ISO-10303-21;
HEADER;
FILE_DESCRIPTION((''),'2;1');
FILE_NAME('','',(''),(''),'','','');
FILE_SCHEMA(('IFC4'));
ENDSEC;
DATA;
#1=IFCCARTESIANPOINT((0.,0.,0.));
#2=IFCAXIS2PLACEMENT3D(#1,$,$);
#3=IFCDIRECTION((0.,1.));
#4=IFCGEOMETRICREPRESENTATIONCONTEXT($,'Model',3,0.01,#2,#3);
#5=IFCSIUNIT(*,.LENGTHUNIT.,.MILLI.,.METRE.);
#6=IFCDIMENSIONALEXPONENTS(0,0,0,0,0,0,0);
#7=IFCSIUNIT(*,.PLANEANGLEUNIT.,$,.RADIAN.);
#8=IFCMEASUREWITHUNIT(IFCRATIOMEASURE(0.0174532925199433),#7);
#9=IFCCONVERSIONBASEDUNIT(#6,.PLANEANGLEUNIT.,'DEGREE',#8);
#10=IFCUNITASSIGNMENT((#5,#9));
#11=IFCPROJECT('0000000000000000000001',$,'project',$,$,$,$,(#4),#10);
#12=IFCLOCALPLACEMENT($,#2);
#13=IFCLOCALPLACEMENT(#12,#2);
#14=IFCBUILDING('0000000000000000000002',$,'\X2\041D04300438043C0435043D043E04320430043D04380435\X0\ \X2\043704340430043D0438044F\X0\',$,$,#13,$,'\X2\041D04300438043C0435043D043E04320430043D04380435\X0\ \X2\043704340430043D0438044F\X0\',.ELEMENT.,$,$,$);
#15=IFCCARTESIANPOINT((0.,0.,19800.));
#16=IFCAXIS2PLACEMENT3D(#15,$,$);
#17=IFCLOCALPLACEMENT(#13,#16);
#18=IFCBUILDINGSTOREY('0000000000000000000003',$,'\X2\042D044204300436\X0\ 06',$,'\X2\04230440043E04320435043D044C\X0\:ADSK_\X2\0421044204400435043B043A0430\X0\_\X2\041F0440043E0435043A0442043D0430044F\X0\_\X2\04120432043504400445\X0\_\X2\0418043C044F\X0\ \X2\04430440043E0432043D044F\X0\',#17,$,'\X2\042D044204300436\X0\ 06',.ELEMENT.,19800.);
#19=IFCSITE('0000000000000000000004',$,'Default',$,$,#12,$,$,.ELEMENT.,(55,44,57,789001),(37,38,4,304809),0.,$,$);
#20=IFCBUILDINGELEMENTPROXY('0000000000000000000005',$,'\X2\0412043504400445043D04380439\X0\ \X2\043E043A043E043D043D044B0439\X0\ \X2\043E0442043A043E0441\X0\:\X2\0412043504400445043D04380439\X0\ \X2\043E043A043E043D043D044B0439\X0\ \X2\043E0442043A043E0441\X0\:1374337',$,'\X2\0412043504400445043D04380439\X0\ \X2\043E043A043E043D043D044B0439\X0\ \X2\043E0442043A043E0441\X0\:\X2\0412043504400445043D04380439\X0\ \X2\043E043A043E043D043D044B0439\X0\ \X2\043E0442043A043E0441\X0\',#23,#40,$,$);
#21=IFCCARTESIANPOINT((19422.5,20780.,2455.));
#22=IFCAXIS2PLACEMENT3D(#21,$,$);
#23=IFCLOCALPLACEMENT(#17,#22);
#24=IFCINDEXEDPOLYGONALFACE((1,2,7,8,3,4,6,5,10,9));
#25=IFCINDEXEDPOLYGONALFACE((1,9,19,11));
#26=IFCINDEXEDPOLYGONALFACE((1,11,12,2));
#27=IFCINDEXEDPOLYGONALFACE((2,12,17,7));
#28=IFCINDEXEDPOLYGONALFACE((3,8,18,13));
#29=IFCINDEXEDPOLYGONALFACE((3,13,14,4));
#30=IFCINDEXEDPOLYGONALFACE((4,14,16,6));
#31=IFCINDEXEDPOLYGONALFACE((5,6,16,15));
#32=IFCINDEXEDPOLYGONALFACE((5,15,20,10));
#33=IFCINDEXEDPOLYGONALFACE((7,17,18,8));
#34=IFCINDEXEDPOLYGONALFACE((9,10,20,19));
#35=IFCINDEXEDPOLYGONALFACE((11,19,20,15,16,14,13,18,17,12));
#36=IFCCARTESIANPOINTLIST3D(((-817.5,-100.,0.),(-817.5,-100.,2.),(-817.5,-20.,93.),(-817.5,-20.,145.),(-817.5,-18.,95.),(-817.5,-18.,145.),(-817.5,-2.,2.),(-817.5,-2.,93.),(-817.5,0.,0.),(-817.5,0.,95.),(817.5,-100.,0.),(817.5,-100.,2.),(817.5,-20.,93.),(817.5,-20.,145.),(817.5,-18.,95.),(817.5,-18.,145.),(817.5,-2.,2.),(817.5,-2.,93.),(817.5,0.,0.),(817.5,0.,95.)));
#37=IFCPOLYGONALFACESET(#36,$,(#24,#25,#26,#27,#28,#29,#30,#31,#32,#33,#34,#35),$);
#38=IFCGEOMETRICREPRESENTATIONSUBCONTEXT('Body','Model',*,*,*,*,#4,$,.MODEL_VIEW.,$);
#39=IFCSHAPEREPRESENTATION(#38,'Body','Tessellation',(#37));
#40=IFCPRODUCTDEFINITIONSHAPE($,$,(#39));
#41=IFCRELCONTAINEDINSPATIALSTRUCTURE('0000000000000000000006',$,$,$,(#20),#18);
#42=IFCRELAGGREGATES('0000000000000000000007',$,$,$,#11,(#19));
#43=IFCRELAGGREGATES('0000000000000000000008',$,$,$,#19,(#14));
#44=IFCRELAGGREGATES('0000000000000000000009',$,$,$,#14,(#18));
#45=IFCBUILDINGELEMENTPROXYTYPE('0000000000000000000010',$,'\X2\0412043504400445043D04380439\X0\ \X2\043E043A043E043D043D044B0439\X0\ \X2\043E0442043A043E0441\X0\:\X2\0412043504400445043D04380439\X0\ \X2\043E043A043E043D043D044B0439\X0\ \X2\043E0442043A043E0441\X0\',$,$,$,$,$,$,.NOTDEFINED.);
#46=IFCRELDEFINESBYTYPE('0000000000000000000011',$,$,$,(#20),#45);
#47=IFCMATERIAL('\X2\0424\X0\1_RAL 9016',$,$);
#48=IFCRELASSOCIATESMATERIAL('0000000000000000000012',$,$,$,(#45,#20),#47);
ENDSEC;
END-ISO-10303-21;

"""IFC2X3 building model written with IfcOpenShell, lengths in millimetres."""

from ifc_helpers import new_model, entity, si_unit, converted_unit, direction, frame, origin, place, context, subcontext, project, spatial, polyline, outline, extrude, source, transform, mapped, material, type_object, type_shapes, element, save


model = new_model("IFC2X3")

# Units and contexts
model_context = context("Model", 3, precision=0.01, world=origin(), true_north=direction((0.0, 1.0)))
body_context = subcontext(model_context, "Body", "Model", "MODEL_VIEW")
ifc_project = project(units=[si_unit("LENGTHUNIT", "METRE", prefix="MILLI"), converted_unit("PLANEANGLEUNIT", "DEGREE", entity("IfcRatioMeasure", 0.0174532925199433), si_unit("PLANEANGLEUNIT", "RADIAN"), dimensions=[0, 0, 0, 0, 0, 0, 0])], contexts=[model_context])

# Site, building, storey
site_placement = place(None, origin())
site = spatial("IfcSite", under=ifc_project, at=site_placement, Name="Default", CompositionType="ELEMENT", RefLatitude=(55, 44, 57, 789001), RefLongitude=(37, 38, 4, 304809), RefElevation=0.0)
building_placement = place(site_placement, origin())
building = spatial("IfcBuilding", under=site, at=building_placement, Name="Наименование здания", LongName="Наименование здания", CompositionType="ELEMENT")
storey_placement = place(building_placement, frame((0.0, 0.0, 19800.0)))
storey = spatial("IfcBuildingStorey", under=building, at=storey_placement, Name="Этаж 06", ObjectType="Уровень:ADSK_Стрелка_Проектная_Вверх_Имя уровня", LongName="Этаж 06", CompositionType="ELEMENT", Elevation=19800.0)

# Building element proxy
ifc_material_1 = material(Name="Ф1_RAL 9016")
building_element_proxy_type_1 = type_object("IfcBuildingElementProxyType", Name="Верхний оконный откос:Верхний оконный откос", PredefinedType="NOTDEFINED", material=ifc_material_1)
shared_shape_1 = source(origin(), body_context, "Body", "SweptSolid", [
    extrude(outline(polyline([(28.0, -10.0), (78.0, -10.0), (78.0, -8.0), (26.0, -8.0), (26.0, -26.0), (-65.0, -26.0), (-65.0, 72.0), (-67.0, 72.0), (-67.0, -28.0), (28.0, -28.0), (28.0, -10.0)])), frame((-817.5, -28.0, 67.0), z_axis=(1.0, 0.0, 0.0), x_axis=(0.0, 0.0, 1.0)), (0.0, 0.0, 1.0), 1635.0),
])
type_shapes(building_element_proxy_type_1, [shared_shape_1])
proxy_1_placement = place(storey_placement, frame((19422.5, 20780.0, 2455.0)))
element("IfcBuildingElementProxy", 1, at=proxy_1_placement, inside=storey, type_object=building_element_proxy_type_1, material=ifc_material_1, Name="Верхний оконный откос:Верхний оконный откос:1374337", ObjectType="Верхний оконный откос:Верхний оконный откос", context=body_context, shape_type="MappedRepresentation", body=[
    mapped(shared_shape_1, transform((0.0, 0.0, 0.0), scale=1.0)),
])

save(model, "model.ifc")
